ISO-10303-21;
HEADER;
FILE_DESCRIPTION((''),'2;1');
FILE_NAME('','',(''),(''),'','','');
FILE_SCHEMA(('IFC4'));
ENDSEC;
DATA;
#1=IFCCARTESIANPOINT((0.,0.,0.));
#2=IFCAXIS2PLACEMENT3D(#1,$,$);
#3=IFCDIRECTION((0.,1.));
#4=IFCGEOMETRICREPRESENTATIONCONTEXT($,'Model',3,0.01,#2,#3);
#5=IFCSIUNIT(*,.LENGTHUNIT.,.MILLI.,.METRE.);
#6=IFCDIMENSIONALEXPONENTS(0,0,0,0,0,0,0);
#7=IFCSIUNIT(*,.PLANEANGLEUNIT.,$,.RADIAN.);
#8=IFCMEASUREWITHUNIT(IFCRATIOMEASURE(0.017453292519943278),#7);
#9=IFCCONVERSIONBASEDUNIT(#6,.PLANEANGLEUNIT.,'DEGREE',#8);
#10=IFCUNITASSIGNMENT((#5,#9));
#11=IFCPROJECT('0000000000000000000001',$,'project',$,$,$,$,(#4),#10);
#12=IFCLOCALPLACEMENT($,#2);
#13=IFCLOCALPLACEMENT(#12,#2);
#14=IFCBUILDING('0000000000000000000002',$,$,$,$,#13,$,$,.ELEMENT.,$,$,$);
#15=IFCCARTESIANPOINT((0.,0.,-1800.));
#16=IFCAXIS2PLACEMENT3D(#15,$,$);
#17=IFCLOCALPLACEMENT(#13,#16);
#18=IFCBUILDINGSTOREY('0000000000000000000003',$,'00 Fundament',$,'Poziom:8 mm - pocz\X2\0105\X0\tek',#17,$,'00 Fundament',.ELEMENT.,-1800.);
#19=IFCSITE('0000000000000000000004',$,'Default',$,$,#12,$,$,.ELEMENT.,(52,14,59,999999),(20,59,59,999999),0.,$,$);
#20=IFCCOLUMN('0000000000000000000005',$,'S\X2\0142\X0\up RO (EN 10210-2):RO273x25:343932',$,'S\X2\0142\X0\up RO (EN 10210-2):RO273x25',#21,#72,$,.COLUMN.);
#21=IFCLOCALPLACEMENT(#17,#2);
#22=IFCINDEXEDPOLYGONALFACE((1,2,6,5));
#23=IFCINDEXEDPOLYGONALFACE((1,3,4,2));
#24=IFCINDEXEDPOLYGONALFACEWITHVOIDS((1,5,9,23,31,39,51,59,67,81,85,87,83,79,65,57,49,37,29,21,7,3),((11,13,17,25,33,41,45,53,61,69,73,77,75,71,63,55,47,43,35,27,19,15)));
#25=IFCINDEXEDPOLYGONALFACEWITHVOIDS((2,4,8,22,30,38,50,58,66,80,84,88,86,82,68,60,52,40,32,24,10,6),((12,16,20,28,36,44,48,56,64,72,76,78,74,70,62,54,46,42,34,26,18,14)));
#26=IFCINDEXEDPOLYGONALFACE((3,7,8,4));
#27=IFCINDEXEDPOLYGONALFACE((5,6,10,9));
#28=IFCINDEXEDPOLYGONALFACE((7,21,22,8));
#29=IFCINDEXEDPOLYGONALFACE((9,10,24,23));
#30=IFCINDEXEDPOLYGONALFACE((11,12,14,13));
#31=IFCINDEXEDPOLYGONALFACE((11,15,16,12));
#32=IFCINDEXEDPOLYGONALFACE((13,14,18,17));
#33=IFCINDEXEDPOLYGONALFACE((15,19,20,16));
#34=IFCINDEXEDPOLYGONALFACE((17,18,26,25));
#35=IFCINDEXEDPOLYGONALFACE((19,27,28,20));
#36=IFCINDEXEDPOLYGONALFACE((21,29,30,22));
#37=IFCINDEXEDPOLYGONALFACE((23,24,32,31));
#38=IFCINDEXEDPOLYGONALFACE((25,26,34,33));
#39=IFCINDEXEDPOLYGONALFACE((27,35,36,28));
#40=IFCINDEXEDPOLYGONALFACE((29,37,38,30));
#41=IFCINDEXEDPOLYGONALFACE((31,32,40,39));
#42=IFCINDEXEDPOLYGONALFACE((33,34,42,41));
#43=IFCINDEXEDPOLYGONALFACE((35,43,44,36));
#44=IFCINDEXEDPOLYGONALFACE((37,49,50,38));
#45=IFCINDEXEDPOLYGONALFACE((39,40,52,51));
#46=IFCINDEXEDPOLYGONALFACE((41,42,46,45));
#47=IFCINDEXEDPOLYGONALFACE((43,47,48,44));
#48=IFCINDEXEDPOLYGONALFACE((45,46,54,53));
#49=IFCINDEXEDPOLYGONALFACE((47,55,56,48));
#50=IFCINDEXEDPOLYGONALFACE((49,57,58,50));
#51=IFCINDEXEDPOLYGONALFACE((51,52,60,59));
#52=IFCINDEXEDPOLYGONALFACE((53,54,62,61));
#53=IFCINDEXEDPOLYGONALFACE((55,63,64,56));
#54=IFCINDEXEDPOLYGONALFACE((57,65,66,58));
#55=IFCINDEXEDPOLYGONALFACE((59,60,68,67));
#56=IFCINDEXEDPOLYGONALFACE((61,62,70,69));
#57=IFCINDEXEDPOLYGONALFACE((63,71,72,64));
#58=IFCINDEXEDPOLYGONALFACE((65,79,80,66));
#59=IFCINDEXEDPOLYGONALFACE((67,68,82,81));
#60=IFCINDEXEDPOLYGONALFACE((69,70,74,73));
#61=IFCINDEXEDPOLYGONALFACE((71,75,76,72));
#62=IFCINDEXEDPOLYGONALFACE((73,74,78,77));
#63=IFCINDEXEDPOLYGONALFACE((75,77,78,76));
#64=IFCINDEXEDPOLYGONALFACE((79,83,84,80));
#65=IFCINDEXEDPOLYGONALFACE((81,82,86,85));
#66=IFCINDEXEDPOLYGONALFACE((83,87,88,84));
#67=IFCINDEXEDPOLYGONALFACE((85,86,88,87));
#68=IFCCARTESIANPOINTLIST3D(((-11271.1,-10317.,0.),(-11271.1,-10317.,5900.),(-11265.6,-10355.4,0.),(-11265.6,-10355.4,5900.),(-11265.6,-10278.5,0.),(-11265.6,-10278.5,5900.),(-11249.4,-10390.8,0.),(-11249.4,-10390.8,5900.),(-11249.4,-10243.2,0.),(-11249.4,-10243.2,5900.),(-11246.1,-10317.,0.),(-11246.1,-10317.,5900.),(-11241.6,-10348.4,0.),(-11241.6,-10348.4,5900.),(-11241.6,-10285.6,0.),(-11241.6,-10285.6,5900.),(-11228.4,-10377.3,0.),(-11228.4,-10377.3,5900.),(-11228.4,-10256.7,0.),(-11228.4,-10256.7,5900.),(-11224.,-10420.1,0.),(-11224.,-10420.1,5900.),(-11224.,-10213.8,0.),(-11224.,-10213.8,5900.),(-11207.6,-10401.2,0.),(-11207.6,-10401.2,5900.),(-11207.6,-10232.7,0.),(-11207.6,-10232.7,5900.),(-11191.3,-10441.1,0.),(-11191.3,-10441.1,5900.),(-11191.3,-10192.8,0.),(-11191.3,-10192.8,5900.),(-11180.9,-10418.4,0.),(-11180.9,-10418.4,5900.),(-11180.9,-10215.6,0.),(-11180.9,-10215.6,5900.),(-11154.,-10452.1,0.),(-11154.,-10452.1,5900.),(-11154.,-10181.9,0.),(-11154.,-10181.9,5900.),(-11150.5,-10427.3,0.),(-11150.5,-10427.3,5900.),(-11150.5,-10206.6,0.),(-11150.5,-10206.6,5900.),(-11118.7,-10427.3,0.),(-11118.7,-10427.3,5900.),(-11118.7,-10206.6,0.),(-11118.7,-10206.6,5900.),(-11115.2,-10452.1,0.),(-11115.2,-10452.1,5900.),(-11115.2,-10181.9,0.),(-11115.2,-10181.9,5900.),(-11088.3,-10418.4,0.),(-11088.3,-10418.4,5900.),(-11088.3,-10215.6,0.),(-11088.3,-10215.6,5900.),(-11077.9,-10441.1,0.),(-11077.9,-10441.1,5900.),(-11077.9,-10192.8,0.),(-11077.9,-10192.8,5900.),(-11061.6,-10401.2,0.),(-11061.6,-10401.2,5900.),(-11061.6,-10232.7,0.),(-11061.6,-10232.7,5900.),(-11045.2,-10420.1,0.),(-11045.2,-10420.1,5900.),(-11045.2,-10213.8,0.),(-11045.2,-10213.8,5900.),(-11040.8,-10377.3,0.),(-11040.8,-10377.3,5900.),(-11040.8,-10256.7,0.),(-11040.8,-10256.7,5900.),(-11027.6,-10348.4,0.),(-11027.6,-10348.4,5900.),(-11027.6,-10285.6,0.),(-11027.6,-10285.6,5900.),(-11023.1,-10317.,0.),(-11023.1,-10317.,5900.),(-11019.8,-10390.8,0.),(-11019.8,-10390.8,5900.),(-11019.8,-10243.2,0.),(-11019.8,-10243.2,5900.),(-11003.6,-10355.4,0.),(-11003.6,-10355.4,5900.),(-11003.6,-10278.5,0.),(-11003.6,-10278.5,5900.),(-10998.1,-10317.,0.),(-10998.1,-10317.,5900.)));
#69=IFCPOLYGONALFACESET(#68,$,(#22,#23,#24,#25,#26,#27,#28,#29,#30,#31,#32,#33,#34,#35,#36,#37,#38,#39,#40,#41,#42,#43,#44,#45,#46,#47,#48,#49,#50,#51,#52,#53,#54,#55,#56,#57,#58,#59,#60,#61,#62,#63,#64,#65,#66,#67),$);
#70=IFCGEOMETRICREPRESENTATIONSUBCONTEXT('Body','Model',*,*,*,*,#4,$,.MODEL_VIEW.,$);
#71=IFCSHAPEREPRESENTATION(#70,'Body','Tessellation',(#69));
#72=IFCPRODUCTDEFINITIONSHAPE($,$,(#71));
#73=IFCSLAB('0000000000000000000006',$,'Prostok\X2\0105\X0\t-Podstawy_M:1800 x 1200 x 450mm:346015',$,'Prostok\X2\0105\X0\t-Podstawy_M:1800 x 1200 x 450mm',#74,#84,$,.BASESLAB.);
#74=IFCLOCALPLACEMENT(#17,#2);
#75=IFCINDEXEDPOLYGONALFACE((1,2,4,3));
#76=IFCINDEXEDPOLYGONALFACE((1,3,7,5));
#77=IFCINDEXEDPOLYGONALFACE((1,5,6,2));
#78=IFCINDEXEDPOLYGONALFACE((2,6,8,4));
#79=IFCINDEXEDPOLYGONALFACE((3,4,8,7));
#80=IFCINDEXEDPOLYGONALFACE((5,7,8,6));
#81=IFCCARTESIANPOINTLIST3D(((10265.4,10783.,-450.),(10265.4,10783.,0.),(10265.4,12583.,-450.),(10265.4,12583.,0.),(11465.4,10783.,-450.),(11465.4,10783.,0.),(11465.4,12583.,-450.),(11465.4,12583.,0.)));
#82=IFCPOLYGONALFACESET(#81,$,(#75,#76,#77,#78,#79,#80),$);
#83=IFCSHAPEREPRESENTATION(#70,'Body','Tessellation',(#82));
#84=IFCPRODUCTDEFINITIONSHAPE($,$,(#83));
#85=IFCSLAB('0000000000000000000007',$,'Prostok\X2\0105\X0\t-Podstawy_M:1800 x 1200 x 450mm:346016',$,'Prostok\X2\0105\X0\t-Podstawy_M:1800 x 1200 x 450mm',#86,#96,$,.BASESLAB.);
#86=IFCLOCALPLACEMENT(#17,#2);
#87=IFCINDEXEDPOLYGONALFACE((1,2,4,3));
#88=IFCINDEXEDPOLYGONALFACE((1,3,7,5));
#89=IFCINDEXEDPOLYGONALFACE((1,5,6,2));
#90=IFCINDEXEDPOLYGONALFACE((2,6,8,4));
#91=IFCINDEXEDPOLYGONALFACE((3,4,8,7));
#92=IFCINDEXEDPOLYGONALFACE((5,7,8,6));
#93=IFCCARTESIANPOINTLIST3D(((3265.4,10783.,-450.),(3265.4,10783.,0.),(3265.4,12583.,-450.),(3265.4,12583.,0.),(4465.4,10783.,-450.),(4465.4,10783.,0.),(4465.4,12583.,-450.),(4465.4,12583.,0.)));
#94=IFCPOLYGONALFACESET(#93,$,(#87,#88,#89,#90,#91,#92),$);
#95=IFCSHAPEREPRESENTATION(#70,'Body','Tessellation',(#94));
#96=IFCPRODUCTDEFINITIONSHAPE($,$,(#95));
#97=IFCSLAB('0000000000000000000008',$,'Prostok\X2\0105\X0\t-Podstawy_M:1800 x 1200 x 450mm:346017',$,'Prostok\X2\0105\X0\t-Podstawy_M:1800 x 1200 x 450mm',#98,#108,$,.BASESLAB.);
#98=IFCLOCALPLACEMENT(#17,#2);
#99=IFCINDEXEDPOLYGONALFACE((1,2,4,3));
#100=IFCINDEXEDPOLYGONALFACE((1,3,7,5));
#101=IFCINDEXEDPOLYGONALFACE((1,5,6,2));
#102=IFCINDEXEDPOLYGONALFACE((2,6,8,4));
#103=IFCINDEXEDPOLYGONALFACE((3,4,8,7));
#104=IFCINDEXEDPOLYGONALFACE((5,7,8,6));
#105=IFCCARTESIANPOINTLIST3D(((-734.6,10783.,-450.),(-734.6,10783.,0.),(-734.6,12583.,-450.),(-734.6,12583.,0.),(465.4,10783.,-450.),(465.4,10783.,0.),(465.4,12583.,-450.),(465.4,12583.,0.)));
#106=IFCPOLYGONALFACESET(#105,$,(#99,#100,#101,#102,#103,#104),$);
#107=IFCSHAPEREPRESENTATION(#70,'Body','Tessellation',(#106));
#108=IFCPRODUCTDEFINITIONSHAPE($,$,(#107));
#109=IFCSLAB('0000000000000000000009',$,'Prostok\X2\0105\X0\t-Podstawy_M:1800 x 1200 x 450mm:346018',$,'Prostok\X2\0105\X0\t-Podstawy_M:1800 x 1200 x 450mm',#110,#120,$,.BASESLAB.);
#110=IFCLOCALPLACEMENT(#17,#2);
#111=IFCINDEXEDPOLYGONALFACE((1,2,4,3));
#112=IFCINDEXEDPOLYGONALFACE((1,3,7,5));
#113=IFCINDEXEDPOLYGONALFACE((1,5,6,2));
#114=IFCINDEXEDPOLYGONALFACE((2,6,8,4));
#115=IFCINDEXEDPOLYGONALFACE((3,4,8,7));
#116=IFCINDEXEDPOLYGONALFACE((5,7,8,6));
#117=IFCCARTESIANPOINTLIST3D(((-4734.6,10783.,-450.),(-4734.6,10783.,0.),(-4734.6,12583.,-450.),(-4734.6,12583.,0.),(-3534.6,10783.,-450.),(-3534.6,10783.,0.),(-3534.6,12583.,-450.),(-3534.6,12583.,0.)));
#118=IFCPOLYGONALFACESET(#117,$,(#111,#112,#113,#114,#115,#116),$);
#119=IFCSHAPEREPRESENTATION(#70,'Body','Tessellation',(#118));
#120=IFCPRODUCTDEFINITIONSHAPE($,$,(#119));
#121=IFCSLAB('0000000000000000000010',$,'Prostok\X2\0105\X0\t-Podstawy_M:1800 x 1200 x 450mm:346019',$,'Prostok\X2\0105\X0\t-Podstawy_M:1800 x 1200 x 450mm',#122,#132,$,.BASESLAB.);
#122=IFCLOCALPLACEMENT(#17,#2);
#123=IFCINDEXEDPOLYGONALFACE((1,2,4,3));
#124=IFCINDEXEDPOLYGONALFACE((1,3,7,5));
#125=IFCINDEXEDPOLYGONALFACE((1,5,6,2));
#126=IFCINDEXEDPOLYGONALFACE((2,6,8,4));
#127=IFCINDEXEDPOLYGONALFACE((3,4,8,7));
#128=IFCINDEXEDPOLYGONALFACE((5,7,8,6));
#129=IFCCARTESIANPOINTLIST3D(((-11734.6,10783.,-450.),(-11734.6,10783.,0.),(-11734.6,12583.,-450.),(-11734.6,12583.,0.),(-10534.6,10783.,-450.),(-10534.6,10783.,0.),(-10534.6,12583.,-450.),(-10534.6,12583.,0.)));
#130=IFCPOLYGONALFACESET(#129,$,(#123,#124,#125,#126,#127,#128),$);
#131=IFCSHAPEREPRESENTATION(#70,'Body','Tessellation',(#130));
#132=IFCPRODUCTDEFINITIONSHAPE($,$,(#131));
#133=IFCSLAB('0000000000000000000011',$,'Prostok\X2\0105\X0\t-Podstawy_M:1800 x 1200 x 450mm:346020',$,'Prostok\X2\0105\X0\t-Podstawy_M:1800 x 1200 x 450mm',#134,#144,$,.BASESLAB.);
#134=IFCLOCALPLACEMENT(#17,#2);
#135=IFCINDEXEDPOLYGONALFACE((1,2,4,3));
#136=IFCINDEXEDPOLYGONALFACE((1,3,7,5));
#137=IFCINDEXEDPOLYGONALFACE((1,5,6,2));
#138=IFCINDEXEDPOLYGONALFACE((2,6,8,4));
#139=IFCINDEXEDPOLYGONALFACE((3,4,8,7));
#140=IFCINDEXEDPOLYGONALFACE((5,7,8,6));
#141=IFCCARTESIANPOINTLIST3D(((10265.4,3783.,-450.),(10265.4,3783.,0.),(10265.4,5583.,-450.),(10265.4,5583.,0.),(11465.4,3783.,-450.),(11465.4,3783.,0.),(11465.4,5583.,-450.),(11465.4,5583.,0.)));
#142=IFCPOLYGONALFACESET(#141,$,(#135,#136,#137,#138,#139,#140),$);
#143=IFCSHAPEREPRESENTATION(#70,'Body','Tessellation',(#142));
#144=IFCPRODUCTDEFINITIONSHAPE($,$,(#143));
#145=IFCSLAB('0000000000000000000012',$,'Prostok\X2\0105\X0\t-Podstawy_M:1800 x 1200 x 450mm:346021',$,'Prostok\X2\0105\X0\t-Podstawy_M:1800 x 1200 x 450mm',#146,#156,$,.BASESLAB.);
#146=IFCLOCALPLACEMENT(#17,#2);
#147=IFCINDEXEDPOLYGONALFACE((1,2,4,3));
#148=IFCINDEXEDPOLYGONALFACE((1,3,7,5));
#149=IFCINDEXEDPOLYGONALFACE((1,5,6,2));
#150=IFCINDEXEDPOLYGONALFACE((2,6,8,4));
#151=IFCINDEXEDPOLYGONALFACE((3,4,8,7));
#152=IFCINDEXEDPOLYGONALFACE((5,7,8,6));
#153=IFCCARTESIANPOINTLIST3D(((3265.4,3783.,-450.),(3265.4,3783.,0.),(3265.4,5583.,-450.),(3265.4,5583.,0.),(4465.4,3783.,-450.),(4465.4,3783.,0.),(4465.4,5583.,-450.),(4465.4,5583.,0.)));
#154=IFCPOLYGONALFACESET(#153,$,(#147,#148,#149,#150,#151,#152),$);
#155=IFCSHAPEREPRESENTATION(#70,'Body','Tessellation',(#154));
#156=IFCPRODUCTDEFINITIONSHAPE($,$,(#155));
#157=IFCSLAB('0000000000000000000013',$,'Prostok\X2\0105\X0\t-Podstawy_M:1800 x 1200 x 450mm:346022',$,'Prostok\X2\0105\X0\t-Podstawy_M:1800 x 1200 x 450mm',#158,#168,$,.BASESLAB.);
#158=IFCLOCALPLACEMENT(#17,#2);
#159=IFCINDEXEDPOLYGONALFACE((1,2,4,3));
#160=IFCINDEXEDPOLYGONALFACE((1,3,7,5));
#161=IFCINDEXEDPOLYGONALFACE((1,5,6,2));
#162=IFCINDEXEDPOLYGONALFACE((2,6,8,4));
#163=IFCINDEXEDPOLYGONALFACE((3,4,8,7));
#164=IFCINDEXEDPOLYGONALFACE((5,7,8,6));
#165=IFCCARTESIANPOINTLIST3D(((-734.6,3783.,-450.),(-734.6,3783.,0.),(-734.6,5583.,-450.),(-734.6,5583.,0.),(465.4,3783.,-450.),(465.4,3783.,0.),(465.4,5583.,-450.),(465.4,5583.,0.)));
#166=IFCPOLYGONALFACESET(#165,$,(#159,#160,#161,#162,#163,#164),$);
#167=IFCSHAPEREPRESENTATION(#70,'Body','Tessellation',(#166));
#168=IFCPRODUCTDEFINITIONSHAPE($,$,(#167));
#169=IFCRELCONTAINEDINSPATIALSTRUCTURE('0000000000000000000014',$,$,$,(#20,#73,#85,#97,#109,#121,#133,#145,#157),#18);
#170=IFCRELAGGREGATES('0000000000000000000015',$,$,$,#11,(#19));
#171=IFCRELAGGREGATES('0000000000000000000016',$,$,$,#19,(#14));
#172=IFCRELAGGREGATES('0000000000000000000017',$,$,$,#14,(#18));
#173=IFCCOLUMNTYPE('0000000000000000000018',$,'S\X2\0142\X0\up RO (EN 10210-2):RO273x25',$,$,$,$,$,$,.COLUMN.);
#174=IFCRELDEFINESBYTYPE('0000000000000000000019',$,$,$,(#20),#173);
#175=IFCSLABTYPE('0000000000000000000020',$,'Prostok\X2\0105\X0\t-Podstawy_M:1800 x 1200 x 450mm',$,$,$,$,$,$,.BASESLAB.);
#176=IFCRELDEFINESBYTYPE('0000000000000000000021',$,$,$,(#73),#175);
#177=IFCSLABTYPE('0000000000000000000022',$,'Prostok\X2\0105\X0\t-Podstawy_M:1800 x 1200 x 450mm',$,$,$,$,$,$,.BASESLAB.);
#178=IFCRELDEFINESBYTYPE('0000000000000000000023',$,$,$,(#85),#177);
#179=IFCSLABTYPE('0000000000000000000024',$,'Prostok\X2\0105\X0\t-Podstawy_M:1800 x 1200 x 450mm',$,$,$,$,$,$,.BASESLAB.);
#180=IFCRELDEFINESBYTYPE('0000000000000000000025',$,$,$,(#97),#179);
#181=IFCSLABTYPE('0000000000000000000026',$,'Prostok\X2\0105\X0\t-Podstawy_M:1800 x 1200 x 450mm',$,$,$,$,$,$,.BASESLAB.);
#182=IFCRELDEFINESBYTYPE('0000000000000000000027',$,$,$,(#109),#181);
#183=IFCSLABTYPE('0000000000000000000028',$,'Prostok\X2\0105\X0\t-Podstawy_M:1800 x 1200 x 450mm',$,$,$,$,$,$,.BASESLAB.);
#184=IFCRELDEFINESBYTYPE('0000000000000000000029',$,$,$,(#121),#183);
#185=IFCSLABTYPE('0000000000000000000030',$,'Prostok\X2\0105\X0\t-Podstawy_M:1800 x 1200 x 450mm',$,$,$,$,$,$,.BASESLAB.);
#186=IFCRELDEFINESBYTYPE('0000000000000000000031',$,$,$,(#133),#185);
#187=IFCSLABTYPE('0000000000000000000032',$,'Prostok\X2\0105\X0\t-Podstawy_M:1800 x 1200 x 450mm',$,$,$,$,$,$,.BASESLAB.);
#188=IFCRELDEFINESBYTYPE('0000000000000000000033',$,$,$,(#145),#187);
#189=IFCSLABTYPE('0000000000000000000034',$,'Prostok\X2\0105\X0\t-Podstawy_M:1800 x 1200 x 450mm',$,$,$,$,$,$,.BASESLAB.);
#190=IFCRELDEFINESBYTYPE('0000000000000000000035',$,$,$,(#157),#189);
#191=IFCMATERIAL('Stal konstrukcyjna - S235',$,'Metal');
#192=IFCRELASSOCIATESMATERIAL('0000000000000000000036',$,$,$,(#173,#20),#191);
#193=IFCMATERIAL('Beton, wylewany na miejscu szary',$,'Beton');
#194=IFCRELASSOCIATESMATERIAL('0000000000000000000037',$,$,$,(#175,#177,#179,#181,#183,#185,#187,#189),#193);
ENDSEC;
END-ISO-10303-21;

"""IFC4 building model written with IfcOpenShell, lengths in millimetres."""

from ifc_helpers import new_model, entity, si_unit, converted_unit, direction, frame, origin, place, context, subcontext, project, spatial, arc, indexed_curve, outline, extrude, source, transform, mapped, material, type_object, type_shapes, element, save


model = new_model("IFC4")

# Units and contexts
model_context = context("Model", 3, precision=0.01, world=origin(), true_north=direction((0.0, 1.0)))
body_context = subcontext(model_context, "Body", "Model", "MODEL_VIEW")
ifc_project = project(units=[si_unit("LENGTHUNIT", "METRE", prefix="MILLI"), converted_unit("PLANEANGLEUNIT", "DEGREE", entity("IfcRatioMeasure", 0.017453292519943278), si_unit("PLANEANGLEUNIT", "RADIAN"), dimensions=[0, 0, 0, 0, 0, 0, 0])], contexts=[model_context])

# Site, building, storey
site_placement = place(None, origin())
site = spatial("IfcSite", under=ifc_project, at=site_placement, Name="Default", CompositionType="ELEMENT", RefLatitude=(52, 14, 59, 999999), RefLongitude=(20, 59, 59, 999999), RefElevation=0.0)
building_placement = place(site_placement, origin())
building = spatial("IfcBuilding", under=site, at=building_placement, CompositionType="ELEMENT")
storey_placement = place(building_placement, frame((0.0, 0.0, -1800.0)))
storey = spatial("IfcBuildingStorey", under=building, at=storey_placement, Name="00 Fundament", ObjectType="Poziom:8 mm - początek", LongName="00 Fundament", CompositionType="ELEMENT", Elevation=-1800.0)

# Column
ifc_material_1 = material(Name="Stal konstrukcyjna - S235", Category="Metal")
column_type = type_object("IfcColumnType", Name="Słup RO (EN 10210-2):RO273x25", PredefinedType="COLUMN", material=ifc_material_1)
shared_shape = source(origin(), body_context, "Body", "SweptSolid", [
    extrude(outline(indexed_curve([(-136.5, 0.0), (0.0, -136.5), (136.5, 0.0), (0.0, 136.5)], segments=[arc(1, 2, 3), arc(3, 4, 1)], self_intersect=False), holes=[indexed_curve([(-111.5, 0.0), (0.0, 111.5), (111.5, 0.0), (0.0, -111.5)], segments=[arc(1, 2, 3), arc(3, 4, 1)], self_intersect=False)]), frame((0.0, 0.0, -1800.0)), (0.0, 0.0, 1.0), 5900.0),
])
type_shapes(column_type, [shared_shape])
for number, where, name in (
    (1, (-11134.6, -10317.0, 1800.0), "Słup RO (EN 10210-2):RO273x25:343932"),
):
    element("IfcColumn", number, at=place(storey_placement, frame(where)), inside=storey, type_object=column_type, material=ifc_material_1, Name=name, ObjectType="Słup RO (EN 10210-2):RO273x25", PredefinedType="COLUMN", context=body_context, shape_type="MappedRepresentation", body=[
        mapped(shared_shape, transform((0.0, 0.0, 0.0), scale=1.0)),
    ])

# Slabs
ifc_material_2 = material(Name="Beton, wylewany na miejscu szary", Category="Beton")
slab_type_1 = type_object("IfcSlabType", Name="Prostokąt-Podstawy_M:1800 x 1200 x 450mm", PredefinedType="BASESLAB", material=ifc_material_2)
slab_1_placement = place(storey_placement, origin())
element("IfcSlab", 2, at=slab_1_placement, inside=storey, type_object=slab_type_1, Name="Prostokąt-Podstawy_M:1800 x 1200 x 450mm:346015", ObjectType="Prostokąt-Podstawy_M:1800 x 1200 x 450mm", PredefinedType="BASESLAB", context=body_context, shape_type="SweptSolid", body=[
    extrude(outline(indexed_curve([(-600.0, -900.0), (600.0, -900.0), (600.0, 900.0), (-600.0, 900.0), (-600.0, -900.0)], self_intersect=False)), frame((10865.4, 11683.0, -450.0), z_axis=(0.0, 0.0, 1.0), x_axis=(-1.0, 0.0, 0.0)), (0.0, 0.0, 1.0), 450.0),
])
slab_type_2 = type_object("IfcSlabType", Name="Prostokąt-Podstawy_M:1800 x 1200 x 450mm", PredefinedType="BASESLAB", material=ifc_material_2)
slab_2_placement = place(storey_placement, origin())
element("IfcSlab", 3, at=slab_2_placement, inside=storey, type_object=slab_type_2, Name="Prostokąt-Podstawy_M:1800 x 1200 x 450mm:346016", ObjectType="Prostokąt-Podstawy_M:1800 x 1200 x 450mm", PredefinedType="BASESLAB", context=body_context, shape_type="SweptSolid", body=[
    extrude(outline(indexed_curve([(-600.0, -900.0), (600.0, -900.0), (600.0, 900.0), (-600.0, 900.0), (-600.0, -900.0)], self_intersect=False)), frame((3865.4, 11683.0, -450.0), z_axis=(0.0, 0.0, 1.0), x_axis=(-1.0, 0.0, 0.0)), (0.0, 0.0, 1.0), 450.0),
])
slab_type_3 = type_object("IfcSlabType", Name="Prostokąt-Podstawy_M:1800 x 1200 x 450mm", PredefinedType="BASESLAB", material=ifc_material_2)
slab_3_placement = place(storey_placement, origin())
element("IfcSlab", 4, at=slab_3_placement, inside=storey, type_object=slab_type_3, Name="Prostokąt-Podstawy_M:1800 x 1200 x 450mm:346017", ObjectType="Prostokąt-Podstawy_M:1800 x 1200 x 450mm", PredefinedType="BASESLAB", context=body_context, shape_type="SweptSolid", body=[
    extrude(outline(indexed_curve([(-600.0, -900.0), (600.0, -900.0), (600.0, 900.0), (-600.0, 900.0), (-600.0, -900.0)], self_intersect=False)), frame((-134.6, 11683.0, -450.0), z_axis=(0.0, 0.0, 1.0), x_axis=(-1.0, 0.0, 0.0)), (0.0, 0.0, 1.0), 450.0),
])
slab_type_4 = type_object("IfcSlabType", Name="Prostokąt-Podstawy_M:1800 x 1200 x 450mm", PredefinedType="BASESLAB", material=ifc_material_2)
slab_4_placement = place(storey_placement, origin())
element("IfcSlab", 5, at=slab_4_placement, inside=storey, type_object=slab_type_4, Name="Prostokąt-Podstawy_M:1800 x 1200 x 450mm:346018", ObjectType="Prostokąt-Podstawy_M:1800 x 1200 x 450mm", PredefinedType="BASESLAB", context=body_context, shape_type="SweptSolid", body=[
    extrude(outline(indexed_curve([(-600.0, -900.0), (600.0, -900.0), (600.0, 900.0), (-600.0, 900.0), (-600.0, -900.0)], self_intersect=False)), frame((-4134.6, 11683.0, -450.0), z_axis=(0.0, 0.0, 1.0), x_axis=(-1.0, 0.0, 0.0)), (0.0, 0.0, 1.0), 450.0),
])
slab_type_5 = type_object("IfcSlabType", Name="Prostokąt-Podstawy_M:1800 x 1200 x 450mm", PredefinedType="BASESLAB", material=ifc_material_2)
slab_5_placement = place(storey_placement, origin())
element("IfcSlab", 6, at=slab_5_placement, inside=storey, type_object=slab_type_5, Name="Prostokąt-Podstawy_M:1800 x 1200 x 450mm:346019", ObjectType="Prostokąt-Podstawy_M:1800 x 1200 x 450mm", PredefinedType="BASESLAB", context=body_context, shape_type="SweptSolid", body=[
    extrude(outline(indexed_curve([(-600.0, -900.0), (600.0, -900.0), (600.0, 900.0), (-600.0, 900.0), (-600.0, -900.0)], self_intersect=False)), frame((-11134.6, 11683.0, -450.0), z_axis=(0.0, 0.0, 1.0), x_axis=(-1.0, 0.0, 0.0)), (0.0, 0.0, 1.0), 450.0),
])
slab_type_6 = type_object("IfcSlabType", Name="Prostokąt-Podstawy_M:1800 x 1200 x 450mm", PredefinedType="BASESLAB", material=ifc_material_2)
slab_6_placement = place(storey_placement, origin())
element("IfcSlab", 7, at=slab_6_placement, inside=storey, type_object=slab_type_6, Name="Prostokąt-Podstawy_M:1800 x 1200 x 450mm:346020", ObjectType="Prostokąt-Podstawy_M:1800 x 1200 x 450mm", PredefinedType="BASESLAB", context=body_context, shape_type="SweptSolid", body=[
    extrude(outline(indexed_curve([(-600.0, -900.0), (600.0, -900.0), (600.0, 900.0), (-600.0, 900.0), (-600.0, -900.0)], self_intersect=False)), frame((10865.4, 4683.0, -450.0), z_axis=(0.0, 0.0, 1.0), x_axis=(-1.0, 0.0, 0.0)), (0.0, 0.0, 1.0), 450.0),
])
slab_type_7 = type_object("IfcSlabType", Name="Prostokąt-Podstawy_M:1800 x 1200 x 450mm", PredefinedType="BASESLAB", material=ifc_material_2)
slab_7_placement = place(storey_placement, origin())
element("IfcSlab", 8, at=slab_7_placement, inside=storey, type_object=slab_type_7, Name="Prostokąt-Podstawy_M:1800 x 1200 x 450mm:346021", ObjectType="Prostokąt-Podstawy_M:1800 x 1200 x 450mm", PredefinedType="BASESLAB", context=body_context, shape_type="SweptSolid", body=[
    extrude(outline(indexed_curve([(-600.0, -900.0), (600.0, -900.0), (600.0, 900.0), (-600.0, 900.0), (-600.0, -900.0)], self_intersect=False)), frame((3865.4, 4683.0, -450.0), z_axis=(0.0, 0.0, 1.0), x_axis=(-1.0, 0.0, 0.0)), (0.0, 0.0, 1.0), 450.0),
])
slab_type_8 = type_object("IfcSlabType", Name="Prostokąt-Podstawy_M:1800 x 1200 x 450mm", PredefinedType="BASESLAB", material=ifc_material_2)
slab_8_placement = place(storey_placement, origin())
element("IfcSlab", 9, at=slab_8_placement, inside=storey, type_object=slab_type_8, Name="Prostokąt-Podstawy_M:1800 x 1200 x 450mm:346022", ObjectType="Prostokąt-Podstawy_M:1800 x 1200 x 450mm", PredefinedType="BASESLAB", context=body_context, shape_type="SweptSolid", body=[
    extrude(outline(indexed_curve([(-600.0, -900.0), (600.0, -900.0), (600.0, 900.0), (-600.0, 900.0), (-600.0, -900.0)], self_intersect=False)), frame((-134.6, 4683.0, -450.0), z_axis=(0.0, 0.0, 1.0), x_axis=(-1.0, 0.0, 0.0)), (0.0, 0.0, 1.0), 450.0),
])

save(model, "model.ifc")
